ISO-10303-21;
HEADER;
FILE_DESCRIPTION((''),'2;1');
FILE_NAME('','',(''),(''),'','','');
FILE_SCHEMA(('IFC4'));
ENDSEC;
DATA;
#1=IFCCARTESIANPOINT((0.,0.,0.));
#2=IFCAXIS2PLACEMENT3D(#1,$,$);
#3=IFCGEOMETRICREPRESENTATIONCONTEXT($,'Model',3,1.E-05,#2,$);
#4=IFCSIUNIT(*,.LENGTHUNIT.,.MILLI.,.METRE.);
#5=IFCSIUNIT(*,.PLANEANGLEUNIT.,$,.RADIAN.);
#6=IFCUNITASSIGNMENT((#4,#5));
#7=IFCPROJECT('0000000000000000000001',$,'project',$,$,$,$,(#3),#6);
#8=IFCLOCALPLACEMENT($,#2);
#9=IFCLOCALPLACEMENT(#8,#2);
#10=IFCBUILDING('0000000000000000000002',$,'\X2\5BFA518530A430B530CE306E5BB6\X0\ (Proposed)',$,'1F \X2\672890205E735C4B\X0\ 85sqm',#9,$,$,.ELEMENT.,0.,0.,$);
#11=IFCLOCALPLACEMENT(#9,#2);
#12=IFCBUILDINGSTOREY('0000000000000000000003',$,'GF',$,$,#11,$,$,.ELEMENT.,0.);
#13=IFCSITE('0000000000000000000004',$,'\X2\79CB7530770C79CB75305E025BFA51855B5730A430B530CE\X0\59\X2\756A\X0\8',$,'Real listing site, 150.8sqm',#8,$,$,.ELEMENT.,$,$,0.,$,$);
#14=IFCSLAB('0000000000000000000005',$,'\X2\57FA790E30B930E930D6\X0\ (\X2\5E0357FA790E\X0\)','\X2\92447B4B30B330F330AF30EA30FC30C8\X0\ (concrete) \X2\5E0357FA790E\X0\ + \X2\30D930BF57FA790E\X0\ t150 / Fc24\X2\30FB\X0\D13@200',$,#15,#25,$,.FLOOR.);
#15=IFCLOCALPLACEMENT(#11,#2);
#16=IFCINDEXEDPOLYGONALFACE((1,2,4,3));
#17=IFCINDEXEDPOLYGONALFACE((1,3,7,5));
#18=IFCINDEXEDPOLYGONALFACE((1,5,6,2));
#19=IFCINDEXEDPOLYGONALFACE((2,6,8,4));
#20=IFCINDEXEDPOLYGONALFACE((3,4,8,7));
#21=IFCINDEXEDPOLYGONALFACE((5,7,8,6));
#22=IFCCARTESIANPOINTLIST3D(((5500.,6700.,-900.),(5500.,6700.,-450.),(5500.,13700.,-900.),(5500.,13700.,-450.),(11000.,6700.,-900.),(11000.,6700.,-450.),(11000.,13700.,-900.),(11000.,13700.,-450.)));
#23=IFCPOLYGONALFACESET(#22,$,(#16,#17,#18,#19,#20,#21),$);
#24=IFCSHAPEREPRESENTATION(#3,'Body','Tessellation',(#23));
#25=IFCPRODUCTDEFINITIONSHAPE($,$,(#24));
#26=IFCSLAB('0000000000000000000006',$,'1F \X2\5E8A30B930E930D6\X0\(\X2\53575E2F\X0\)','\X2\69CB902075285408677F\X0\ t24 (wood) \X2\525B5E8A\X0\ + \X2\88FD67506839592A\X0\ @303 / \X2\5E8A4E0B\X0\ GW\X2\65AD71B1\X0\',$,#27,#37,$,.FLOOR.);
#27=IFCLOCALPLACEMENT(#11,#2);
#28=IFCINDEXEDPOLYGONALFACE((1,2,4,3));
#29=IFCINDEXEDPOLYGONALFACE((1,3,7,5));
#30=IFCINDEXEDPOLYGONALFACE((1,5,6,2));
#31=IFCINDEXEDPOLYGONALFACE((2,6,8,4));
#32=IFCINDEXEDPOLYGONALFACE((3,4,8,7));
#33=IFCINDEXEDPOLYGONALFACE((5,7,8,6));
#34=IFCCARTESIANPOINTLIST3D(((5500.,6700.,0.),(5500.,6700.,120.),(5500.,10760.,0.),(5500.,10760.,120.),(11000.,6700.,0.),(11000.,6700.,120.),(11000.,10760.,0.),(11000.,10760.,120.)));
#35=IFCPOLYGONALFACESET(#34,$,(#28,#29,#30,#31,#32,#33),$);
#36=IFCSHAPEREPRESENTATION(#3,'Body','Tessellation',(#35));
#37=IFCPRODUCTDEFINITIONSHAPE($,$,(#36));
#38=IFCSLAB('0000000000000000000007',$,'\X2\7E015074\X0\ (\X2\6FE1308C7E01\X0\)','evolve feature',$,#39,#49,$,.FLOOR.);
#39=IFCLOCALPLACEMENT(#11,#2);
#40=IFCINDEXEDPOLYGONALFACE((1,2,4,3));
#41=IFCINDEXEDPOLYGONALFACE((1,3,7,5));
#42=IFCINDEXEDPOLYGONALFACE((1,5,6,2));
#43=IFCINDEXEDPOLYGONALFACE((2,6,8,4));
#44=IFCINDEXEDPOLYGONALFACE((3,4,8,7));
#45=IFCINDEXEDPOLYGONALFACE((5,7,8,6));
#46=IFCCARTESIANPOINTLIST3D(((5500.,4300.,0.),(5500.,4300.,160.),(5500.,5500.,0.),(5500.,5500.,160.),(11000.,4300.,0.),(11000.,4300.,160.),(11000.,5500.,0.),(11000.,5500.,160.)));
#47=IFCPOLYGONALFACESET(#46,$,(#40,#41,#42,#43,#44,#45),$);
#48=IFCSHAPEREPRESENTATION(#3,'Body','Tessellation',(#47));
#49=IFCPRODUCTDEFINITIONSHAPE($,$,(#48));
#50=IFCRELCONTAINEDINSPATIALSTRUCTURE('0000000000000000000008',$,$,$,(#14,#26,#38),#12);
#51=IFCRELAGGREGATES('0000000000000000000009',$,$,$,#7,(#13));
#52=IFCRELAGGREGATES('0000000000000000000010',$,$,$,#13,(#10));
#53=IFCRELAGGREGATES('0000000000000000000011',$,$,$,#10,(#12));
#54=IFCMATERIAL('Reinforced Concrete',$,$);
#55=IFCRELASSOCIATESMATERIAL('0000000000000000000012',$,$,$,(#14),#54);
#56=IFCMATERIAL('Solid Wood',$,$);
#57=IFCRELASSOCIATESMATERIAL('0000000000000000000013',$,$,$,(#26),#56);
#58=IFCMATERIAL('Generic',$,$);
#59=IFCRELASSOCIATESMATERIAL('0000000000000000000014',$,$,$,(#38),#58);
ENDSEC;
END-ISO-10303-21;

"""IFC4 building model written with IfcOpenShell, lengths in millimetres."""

from ifc_helpers import new_model, si_unit, frame, frame_2d, origin, place, context, project, spatial, rectangle, extrude, material, element, save


model = new_model("IFC4")

# Units and contexts
model_context = context("Model", 3, precision=1e-05, world=origin())
ifc_project = project(units=[si_unit("LENGTHUNIT", "METRE", prefix="MILLI"), si_unit("PLANEANGLEUNIT", "RADIAN")], contexts=[model_context])

# Site, building, storey
site_placement = place(None, origin())
site = spatial("IfcSite", under=ifc_project, at=site_placement, Name="秋田県秋田市寺内字イサノ59番8", ObjectType="Real listing site, 150.8sqm", CompositionType="ELEMENT", RefElevation=0.0)
building_placement = place(site_placement, origin())
building = spatial("IfcBuilding", under=site, at=building_placement, Name="寺内イサノの家 (Proposed)", ObjectType="1F 木造平屋 85sqm", CompositionType="ELEMENT", ElevationOfRefHeight=0.0, ElevationOfTerrain=0.0)
storey_placement = place(building_placement, origin())
storey = spatial("IfcBuildingStorey", under=building, at=storey_placement, Name="GF", CompositionType="ELEMENT", Elevation=0.0)

# Slabs
ifc_material_1 = material(Name="Reinforced Concrete")
slab_1_placement = place(storey_placement, frame((2750.0, 3350.0, -450.0)))
element("IfcSlab", 1, at=slab_1_placement, inside=storey, material=ifc_material_1, Name="基礎スラブ (布基礎)", Description="鉄筋コンクリート (concrete) 布基礎 + ベタ基礎 t150 / Fc24・D13@200", PredefinedType="FLOOR", context=model_context, shape_type="SweptSolid", body=[
    extrude(rectangle(XDim=5500.0, YDim=7000.0, at=frame_2d((2750.0, 3500.0))), frame((2750.0, 3350.0, -450.0)), (0.0, 0.0, 1.0), 450.0),
])
ifc_material_2 = material(Name="Solid Wood")
slab_2_placement = place(storey_placement, frame((2750.0, 3350.0, 0.0)))
element("IfcSlab", 2, at=slab_2_placement, inside=storey, material=ifc_material_2, Name="1F 床スラブ(南帯)", Description="構造用合板 t24 (wood) 剛床 + 製材根太 @303 / 床下 GW断熱", PredefinedType="FLOOR", context=model_context, shape_type="SweptSolid", body=[
    extrude(rectangle(XDim=5500.0, YDim=4060.0, at=frame_2d((2750.0, 2030.0))), frame((2750.0, 3350.0, 0.0)), (0.0, 0.0, 1.0), 120.0),
])
ifc_material_3 = material(Name="Generic")
slab_3_placement = place(storey_placement, frame((2750.0, 2150.0, 0.0)))
element("IfcSlab", 3, at=slab_3_placement, inside=storey, material=ifc_material_3, Name="縁側 (濡れ縁)", Description="evolve feature", PredefinedType="FLOOR", context=model_context, shape_type="SweptSolid", body=[
    extrude(rectangle(XDim=5500.0, YDim=1200.0, at=frame_2d((2750.0, 600.0))), frame((2750.0, 2150.0, 0.0)), (0.0, 0.0, 1.0), 160.0),
])

save(model, "model.ifc")
